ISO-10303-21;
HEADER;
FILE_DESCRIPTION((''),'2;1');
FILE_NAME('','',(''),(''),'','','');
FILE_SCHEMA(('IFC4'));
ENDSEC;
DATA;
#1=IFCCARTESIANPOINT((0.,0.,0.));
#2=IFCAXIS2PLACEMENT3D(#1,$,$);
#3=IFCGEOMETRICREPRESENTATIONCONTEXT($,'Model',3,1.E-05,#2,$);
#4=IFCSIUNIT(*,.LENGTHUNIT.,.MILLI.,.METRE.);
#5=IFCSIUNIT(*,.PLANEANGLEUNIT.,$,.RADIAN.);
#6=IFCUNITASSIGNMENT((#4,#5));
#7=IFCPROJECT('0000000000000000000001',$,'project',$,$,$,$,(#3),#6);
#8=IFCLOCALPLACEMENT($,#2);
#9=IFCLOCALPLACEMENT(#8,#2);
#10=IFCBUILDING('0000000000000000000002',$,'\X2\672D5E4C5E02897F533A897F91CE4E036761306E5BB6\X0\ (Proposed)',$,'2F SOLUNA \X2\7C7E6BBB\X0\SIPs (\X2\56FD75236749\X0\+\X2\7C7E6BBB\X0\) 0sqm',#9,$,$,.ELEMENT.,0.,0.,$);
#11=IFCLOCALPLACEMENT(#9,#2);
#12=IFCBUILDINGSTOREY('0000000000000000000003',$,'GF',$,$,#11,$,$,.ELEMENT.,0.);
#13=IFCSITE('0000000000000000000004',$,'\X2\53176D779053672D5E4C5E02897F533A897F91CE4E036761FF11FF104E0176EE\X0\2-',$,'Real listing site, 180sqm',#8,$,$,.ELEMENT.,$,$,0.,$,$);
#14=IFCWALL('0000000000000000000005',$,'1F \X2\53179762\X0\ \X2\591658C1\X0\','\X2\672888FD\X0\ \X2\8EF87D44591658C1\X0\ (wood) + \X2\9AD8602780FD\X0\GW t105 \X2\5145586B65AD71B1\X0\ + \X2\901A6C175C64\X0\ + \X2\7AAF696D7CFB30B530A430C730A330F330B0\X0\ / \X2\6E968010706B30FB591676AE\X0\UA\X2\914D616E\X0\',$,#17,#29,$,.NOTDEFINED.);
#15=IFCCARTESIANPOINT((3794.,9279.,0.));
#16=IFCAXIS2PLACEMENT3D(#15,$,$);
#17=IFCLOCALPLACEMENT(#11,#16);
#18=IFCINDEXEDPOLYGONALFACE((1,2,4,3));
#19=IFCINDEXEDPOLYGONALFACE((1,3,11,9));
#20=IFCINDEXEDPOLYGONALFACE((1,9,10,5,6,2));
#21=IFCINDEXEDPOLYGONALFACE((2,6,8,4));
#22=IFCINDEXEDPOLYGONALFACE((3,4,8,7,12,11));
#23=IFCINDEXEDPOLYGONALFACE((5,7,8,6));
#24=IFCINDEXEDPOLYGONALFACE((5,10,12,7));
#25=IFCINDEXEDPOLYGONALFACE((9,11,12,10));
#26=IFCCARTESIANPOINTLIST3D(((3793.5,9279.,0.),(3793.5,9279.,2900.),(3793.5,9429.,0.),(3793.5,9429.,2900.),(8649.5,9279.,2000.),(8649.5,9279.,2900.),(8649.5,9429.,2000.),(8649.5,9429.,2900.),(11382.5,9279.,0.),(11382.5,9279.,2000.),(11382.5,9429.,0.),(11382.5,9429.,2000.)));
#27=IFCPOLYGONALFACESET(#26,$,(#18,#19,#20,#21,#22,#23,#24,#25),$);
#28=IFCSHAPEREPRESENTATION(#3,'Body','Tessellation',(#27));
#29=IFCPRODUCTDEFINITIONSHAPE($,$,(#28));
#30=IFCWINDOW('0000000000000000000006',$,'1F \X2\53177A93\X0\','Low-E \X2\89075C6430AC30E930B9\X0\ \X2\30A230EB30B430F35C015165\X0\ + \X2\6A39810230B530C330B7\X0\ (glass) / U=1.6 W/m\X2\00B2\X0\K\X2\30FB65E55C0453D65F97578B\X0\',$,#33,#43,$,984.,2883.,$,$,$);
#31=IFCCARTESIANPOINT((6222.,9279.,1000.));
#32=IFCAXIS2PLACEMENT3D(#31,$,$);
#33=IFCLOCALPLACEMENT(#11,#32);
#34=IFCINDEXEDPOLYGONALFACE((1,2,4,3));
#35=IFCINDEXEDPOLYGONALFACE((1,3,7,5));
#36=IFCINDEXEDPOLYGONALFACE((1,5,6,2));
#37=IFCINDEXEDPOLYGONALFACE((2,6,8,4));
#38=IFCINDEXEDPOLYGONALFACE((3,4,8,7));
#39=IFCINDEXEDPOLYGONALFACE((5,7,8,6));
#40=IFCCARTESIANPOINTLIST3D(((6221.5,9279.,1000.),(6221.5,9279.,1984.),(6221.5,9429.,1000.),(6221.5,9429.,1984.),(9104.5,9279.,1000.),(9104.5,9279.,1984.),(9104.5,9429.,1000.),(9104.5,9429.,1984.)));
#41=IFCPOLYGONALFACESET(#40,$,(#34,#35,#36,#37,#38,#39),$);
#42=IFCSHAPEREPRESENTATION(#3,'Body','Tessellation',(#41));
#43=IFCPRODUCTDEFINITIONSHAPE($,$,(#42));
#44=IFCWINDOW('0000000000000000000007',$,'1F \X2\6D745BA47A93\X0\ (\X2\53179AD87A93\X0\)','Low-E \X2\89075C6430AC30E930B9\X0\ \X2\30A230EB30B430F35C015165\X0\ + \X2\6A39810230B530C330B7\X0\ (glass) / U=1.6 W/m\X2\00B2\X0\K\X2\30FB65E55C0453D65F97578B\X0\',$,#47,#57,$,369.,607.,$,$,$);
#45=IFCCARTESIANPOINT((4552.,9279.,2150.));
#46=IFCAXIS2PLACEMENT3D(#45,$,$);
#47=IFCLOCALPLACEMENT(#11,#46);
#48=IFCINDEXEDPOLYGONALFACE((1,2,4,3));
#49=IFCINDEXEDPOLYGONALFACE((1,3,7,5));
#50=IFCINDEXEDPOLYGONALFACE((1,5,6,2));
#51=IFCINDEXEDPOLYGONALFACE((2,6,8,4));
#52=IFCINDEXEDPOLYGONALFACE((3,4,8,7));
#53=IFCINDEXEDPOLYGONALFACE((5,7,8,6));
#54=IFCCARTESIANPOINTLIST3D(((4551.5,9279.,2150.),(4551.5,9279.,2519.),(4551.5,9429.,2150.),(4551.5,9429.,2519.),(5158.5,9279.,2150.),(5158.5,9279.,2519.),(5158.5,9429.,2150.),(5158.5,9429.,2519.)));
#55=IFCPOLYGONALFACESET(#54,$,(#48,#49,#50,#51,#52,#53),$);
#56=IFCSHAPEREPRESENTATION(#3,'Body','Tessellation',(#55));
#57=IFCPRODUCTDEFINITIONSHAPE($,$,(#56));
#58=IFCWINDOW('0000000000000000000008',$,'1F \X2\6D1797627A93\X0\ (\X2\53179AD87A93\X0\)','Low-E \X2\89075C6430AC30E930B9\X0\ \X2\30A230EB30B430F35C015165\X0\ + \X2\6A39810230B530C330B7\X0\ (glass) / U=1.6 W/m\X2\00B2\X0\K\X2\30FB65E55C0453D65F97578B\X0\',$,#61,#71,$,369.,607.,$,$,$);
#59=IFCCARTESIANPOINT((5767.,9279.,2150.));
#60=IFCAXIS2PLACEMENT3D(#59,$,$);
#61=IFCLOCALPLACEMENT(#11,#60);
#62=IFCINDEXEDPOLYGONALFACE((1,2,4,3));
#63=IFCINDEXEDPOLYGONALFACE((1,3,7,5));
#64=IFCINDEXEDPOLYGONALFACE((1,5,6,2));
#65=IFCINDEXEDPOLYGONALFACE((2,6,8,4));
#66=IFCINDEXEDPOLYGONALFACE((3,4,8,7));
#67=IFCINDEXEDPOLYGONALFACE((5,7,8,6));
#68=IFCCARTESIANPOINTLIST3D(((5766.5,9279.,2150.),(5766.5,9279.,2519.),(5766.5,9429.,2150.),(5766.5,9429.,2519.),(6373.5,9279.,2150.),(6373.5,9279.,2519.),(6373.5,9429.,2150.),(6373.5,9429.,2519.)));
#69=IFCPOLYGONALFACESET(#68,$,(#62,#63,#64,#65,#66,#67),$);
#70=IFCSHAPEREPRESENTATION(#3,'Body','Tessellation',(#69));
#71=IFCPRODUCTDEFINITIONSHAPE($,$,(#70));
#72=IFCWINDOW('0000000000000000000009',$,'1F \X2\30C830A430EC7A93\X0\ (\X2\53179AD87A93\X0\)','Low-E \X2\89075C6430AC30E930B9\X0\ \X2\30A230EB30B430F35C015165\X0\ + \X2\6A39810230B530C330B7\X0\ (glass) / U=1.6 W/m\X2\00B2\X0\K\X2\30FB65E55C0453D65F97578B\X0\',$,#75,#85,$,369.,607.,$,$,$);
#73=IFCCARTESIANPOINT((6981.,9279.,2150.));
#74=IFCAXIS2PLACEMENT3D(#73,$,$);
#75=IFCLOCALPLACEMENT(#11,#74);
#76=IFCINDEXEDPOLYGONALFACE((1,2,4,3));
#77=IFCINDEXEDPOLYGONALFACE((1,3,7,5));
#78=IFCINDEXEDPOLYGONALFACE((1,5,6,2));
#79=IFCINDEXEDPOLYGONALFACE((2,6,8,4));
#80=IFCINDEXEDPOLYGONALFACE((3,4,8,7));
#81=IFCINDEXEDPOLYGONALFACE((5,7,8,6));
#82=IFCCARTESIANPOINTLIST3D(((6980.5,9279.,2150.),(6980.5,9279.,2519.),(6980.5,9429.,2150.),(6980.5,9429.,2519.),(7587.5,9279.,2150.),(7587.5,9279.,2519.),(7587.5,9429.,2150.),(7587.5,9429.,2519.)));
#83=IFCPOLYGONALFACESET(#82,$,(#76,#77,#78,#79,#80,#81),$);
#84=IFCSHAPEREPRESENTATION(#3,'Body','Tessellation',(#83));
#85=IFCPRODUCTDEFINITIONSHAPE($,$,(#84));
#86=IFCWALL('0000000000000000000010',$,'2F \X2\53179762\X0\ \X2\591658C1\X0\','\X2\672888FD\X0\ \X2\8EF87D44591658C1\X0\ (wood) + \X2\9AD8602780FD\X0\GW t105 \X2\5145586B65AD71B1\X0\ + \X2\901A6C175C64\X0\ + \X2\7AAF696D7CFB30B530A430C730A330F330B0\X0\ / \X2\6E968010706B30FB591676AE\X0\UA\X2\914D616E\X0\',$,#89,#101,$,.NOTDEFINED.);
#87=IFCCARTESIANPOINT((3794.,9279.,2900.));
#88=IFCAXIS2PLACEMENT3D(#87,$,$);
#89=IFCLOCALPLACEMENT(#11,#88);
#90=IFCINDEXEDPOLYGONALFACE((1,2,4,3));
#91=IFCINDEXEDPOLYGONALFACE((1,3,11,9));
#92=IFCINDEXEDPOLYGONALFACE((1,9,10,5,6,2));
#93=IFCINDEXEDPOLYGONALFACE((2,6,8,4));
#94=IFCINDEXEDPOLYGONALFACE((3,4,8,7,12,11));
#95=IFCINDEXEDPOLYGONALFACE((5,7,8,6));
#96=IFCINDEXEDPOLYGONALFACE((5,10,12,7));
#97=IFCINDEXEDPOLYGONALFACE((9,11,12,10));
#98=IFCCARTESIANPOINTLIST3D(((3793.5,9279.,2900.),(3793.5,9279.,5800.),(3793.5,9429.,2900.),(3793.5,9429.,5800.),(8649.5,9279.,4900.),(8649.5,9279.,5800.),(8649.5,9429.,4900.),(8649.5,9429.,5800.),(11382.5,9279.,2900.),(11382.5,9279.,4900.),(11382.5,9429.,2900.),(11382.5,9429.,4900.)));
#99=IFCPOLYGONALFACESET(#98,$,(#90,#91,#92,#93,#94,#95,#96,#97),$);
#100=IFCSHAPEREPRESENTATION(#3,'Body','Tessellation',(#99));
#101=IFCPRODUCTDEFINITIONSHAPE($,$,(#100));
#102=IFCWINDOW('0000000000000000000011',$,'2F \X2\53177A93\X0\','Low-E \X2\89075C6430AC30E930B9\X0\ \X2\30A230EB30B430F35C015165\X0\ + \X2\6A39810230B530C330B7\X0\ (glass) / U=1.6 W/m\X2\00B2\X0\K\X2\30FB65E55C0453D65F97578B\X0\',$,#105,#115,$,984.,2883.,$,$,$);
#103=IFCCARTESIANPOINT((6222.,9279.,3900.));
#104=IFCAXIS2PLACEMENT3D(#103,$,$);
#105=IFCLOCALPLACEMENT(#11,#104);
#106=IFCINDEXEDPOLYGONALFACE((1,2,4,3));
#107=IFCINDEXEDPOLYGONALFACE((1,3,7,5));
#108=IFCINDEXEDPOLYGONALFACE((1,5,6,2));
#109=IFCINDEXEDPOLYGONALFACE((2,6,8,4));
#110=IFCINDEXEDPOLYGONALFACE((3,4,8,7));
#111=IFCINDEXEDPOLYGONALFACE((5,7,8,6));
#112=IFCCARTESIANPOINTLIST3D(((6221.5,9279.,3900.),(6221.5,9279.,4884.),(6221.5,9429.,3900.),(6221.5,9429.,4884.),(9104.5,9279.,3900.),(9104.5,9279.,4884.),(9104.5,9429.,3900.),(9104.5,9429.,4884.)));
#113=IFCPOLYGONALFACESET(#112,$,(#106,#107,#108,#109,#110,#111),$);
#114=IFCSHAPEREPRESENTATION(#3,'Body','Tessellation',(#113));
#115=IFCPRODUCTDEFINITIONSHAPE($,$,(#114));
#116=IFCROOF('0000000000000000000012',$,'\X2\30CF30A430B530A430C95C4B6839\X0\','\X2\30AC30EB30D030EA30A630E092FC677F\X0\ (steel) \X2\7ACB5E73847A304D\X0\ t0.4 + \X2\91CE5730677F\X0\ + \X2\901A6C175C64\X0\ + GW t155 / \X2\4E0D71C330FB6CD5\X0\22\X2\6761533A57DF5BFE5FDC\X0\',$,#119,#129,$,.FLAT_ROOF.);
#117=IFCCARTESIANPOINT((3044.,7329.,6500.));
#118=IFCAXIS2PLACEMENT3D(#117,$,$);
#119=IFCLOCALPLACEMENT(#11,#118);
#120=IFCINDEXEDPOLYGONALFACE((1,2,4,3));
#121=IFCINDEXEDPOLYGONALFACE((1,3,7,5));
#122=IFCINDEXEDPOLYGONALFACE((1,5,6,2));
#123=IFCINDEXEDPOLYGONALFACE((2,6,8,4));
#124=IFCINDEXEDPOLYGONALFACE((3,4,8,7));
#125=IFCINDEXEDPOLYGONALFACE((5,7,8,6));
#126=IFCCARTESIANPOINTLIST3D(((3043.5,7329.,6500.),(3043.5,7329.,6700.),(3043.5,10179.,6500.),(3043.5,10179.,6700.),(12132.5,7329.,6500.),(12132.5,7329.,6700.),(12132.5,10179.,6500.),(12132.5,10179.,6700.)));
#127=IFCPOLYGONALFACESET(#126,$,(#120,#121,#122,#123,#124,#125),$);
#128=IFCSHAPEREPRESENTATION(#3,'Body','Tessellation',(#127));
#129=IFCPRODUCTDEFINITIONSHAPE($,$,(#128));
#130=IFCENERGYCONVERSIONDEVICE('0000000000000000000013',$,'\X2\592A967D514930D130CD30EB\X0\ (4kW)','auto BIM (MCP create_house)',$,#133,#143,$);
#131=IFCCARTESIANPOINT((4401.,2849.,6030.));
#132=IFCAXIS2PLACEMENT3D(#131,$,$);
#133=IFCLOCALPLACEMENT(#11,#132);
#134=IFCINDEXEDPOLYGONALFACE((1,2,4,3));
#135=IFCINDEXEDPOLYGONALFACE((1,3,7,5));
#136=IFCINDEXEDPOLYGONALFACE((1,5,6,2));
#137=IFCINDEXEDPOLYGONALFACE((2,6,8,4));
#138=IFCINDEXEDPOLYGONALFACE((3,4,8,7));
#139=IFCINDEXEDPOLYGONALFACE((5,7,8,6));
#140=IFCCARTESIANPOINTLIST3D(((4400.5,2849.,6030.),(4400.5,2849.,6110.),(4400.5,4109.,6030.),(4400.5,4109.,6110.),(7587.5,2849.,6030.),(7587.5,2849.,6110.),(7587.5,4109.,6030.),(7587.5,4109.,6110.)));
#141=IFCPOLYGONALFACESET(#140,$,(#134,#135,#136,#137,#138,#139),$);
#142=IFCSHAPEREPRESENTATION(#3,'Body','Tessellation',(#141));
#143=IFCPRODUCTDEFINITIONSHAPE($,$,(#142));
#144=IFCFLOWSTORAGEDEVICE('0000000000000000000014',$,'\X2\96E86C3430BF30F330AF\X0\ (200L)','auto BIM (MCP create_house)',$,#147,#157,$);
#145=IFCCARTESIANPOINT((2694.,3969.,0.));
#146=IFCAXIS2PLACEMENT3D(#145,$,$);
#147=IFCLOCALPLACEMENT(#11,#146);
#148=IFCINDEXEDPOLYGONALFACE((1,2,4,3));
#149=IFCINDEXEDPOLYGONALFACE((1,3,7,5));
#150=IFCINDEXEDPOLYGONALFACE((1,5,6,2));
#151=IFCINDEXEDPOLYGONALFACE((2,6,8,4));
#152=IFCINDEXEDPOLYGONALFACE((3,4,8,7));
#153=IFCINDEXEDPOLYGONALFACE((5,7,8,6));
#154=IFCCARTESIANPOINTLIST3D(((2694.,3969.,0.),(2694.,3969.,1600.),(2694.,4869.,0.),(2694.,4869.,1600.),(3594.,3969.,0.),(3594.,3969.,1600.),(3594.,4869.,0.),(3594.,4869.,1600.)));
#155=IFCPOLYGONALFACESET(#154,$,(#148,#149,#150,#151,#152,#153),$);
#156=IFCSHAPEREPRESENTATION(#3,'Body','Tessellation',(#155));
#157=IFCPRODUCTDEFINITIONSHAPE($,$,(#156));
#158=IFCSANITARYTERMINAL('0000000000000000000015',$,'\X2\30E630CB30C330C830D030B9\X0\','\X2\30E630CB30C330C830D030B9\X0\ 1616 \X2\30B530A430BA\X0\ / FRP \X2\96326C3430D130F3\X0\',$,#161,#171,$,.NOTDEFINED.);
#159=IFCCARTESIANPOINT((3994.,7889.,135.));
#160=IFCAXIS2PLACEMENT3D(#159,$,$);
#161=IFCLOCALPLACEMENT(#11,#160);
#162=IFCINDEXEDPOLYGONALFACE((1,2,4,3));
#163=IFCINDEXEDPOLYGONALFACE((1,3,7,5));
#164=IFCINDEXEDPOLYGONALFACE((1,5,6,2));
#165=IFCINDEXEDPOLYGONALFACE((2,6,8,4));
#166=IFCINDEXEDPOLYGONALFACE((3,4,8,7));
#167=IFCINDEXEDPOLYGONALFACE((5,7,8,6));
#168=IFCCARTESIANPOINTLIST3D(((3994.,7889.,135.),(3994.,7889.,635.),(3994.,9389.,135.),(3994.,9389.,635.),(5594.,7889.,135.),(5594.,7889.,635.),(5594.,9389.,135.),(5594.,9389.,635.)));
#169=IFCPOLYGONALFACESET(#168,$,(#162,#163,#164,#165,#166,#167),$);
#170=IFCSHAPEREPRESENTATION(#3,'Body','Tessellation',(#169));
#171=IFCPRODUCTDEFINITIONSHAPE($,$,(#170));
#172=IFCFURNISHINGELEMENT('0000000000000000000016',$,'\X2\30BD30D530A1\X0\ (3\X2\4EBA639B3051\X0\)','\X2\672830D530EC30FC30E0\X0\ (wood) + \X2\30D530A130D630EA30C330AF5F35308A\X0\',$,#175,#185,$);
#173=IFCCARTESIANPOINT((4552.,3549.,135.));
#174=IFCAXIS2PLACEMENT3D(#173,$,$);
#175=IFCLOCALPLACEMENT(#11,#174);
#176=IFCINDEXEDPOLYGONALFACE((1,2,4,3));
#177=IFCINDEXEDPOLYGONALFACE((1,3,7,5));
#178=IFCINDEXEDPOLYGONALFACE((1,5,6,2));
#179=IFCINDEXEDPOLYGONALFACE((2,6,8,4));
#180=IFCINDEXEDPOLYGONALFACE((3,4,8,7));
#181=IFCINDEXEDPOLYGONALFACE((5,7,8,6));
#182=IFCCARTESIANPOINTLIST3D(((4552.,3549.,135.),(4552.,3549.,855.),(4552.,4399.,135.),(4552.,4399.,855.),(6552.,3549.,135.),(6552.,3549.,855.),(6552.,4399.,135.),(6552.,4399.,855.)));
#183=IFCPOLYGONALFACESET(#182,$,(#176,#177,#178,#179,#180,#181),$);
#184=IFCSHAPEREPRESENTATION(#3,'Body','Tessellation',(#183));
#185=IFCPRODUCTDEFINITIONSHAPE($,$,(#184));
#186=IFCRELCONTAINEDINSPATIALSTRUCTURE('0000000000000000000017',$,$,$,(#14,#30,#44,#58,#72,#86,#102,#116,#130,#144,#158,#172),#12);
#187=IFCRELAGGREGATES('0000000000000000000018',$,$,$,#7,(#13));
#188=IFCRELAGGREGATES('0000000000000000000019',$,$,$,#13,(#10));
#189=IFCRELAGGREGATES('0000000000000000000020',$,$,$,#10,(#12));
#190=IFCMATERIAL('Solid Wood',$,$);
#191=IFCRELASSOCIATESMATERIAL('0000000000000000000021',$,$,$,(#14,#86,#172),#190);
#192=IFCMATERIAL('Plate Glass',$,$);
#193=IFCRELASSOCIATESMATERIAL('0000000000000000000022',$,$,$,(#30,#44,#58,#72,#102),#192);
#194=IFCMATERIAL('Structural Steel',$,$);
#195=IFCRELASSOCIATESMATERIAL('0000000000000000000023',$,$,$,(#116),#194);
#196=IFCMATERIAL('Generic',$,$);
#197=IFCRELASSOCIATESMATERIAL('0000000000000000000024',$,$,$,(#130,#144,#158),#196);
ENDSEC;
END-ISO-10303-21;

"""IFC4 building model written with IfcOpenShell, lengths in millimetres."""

from ifc_helpers import new_model, si_unit, frame, frame_2d, origin, place, context, project, spatial, rectangle, extrude, material, element, fill, save


model = new_model("IFC4")

# Units and contexts
model_context = context("Model", 3, precision=1e-05, world=origin())
ifc_project = project(units=[si_unit("LENGTHUNIT", "METRE", prefix="MILLI"), si_unit("PLANEANGLEUNIT", "RADIAN")], contexts=[model_context])

# Site, building, storey
site_placement = place(None, origin())
site = spatial("IfcSite", under=ifc_project, at=site_placement, Name="北海道札幌市西区西野七条１０丁目2-", ObjectType="Real listing site, 180sqm", CompositionType="ELEMENT", RefElevation=0.0)
building_placement = place(site_placement, origin())
building = spatial("IfcBuilding", under=site, at=building_placement, Name="札幌市西区西野七条の家 (Proposed)", ObjectType="2F SOLUNA 籾殻SIPs (国産杉+籾殻) 0sqm", CompositionType="ELEMENT", ElevationOfRefHeight=0.0, ElevationOfTerrain=0.0)
storey_placement = place(building_placement, origin())
storey = spatial("IfcBuildingStorey", under=building, at=storey_placement, Name="GF", CompositionType="ELEMENT", Elevation=0.0)

# Wall, openings, windows
ifc_material_1 = material(Name="Solid Wood")
wall_1_placement = place(storey_placement, frame((3794.0, 9279.0, 0.0)))
wall_1 = element("IfcWall", 1, at=wall_1_placement, inside=storey, material=ifc_material_1, Name="1F 北面 外壁", Description="木製 軸組外壁 (wood) + 高性能GW t105 充填断熱 + 通気層 + 窯業系サイディング / 準耐火・外皮UA配慮", PredefinedType="NOTDEFINED", context=model_context, shape_type="SweptSolid", body=[
    extrude(rectangle(XDim=7589.0, YDim=150.0, at=frame_2d((3794.0, 75.0))), frame((3794.0, 9279.0, 0.0)), (0.0, 0.0, 1.0), 2900.0),
])
opening_1_placement = place(storey_placement, frame((6222.0, 9279.0, 1000.0)))
opening_1 = element("IfcOpeningElement", 2, at=opening_1_placement, cuts=wall_1, PredefinedType="NOTDEFINED", context=model_context, shape_type="SweptSolid", body=[
    extrude(rectangle(XDim=2883.0, YDim=150.0, at=frame_2d((1441.0, 75.0))), frame((6222.0, 9279.0, 1000.0)), (0.0, 0.0, 1.0), 984.0),
])
opening_2_placement = place(storey_placement, frame((4552.0, 9279.0, 2150.0)))
opening_2 = element("IfcOpeningElement", 3, at=opening_2_placement, cuts=wall_1, PredefinedType="NOTDEFINED", context=model_context, shape_type="SweptSolid", body=[
    extrude(rectangle(XDim=607.0, YDim=150.0, at=frame_2d((303.0, 75.0))), frame((4552.0, 9279.0, 2150.0)), (0.0, 0.0, 1.0), 369.0),
])
opening_3_placement = place(storey_placement, frame((5767.0, 9279.0, 2150.0)))
opening_3 = element("IfcOpeningElement", 4, at=opening_3_placement, cuts=wall_1, PredefinedType="NOTDEFINED", context=model_context, shape_type="SweptSolid", body=[
    extrude(rectangle(XDim=607.0, YDim=150.0, at=frame_2d((303.0, 75.0))), frame((5767.0, 9279.0, 2150.0)), (0.0, 0.0, 1.0), 369.0),
])
opening_4_placement = place(storey_placement, frame((6981.0, 9279.0, 2150.0)))
opening_4 = element("IfcOpeningElement", 5, at=opening_4_placement, cuts=wall_1, PredefinedType="NOTDEFINED", context=model_context, shape_type="SweptSolid", body=[
    extrude(rectangle(XDim=607.0, YDim=150.0, at=frame_2d((303.0, 75.0))), frame((6981.0, 9279.0, 2150.0)), (0.0, 0.0, 1.0), 369.0),
])
ifc_material_2 = material(Name="Plate Glass")
window_1_placement = place(storey_placement, frame((6222.0, 9279.0, 1000.0)))
window_1 = element("IfcWindow", 6, at=window_1_placement, inside=storey, material=ifc_material_2, Name="1F 北窓", Description="Low-E 複層ガラス アルゴン封入 + 樹脂サッシ (glass) / U=1.6 W/m²K・日射取得型", OverallHeight=984.0, OverallWidth=2883.0, context=model_context, shape_type="SweptSolid", body=[
    extrude(rectangle(XDim=2883.0, YDim=150.0, at=frame_2d((1441.0, 75.0))), frame((6222.0, 9279.0, 1000.0)), (0.0, 0.0, 1.0), 984.0),
])
fill(opening_1, window_1)
window_2_placement = place(storey_placement, frame((4552.0, 9279.0, 2150.0)))
window_2 = element("IfcWindow", 7, at=window_2_placement, inside=storey, material=ifc_material_2, Name="1F 浴室窓 (北高窓)", Description="Low-E 複層ガラス アルゴン封入 + 樹脂サッシ (glass) / U=1.6 W/m²K・日射取得型", OverallHeight=369.0, OverallWidth=607.0, context=model_context, shape_type="SweptSolid", body=[
    extrude(rectangle(XDim=607.0, YDim=150.0, at=frame_2d((303.0, 75.0))), frame((4552.0, 9279.0, 2150.0)), (0.0, 0.0, 1.0), 369.0),
])
fill(opening_2, window_2)
window_3_placement = place(storey_placement, frame((5767.0, 9279.0, 2150.0)))
window_3 = element("IfcWindow", 8, at=window_3_placement, inside=storey, material=ifc_material_2, Name="1F 洗面窓 (北高窓)", Description="Low-E 複層ガラス アルゴン封入 + 樹脂サッシ (glass) / U=1.6 W/m²K・日射取得型", OverallHeight=369.0, OverallWidth=607.0, context=model_context, shape_type="SweptSolid", body=[
    extrude(rectangle(XDim=607.0, YDim=150.0, at=frame_2d((303.0, 75.0))), frame((5767.0, 9279.0, 2150.0)), (0.0, 0.0, 1.0), 369.0),
])
fill(opening_3, window_3)
window_4_placement = place(storey_placement, frame((6981.0, 9279.0, 2150.0)))
window_4 = element("IfcWindow", 9, at=window_4_placement, inside=storey, material=ifc_material_2, Name="1F トイレ窓 (北高窓)", Description="Low-E 複層ガラス アルゴン封入 + 樹脂サッシ (glass) / U=1.6 W/m²K・日射取得型", OverallHeight=369.0, OverallWidth=607.0, context=model_context, shape_type="SweptSolid", body=[
    extrude(rectangle(XDim=607.0, YDim=150.0, at=frame_2d((303.0, 75.0))), frame((6981.0, 9279.0, 2150.0)), (0.0, 0.0, 1.0), 369.0),
])
fill(opening_4, window_4)

# Wall, opening, window
wall_2_placement = place(storey_placement, frame((3794.0, 9279.0, 2900.0)))
wall_2 = element("IfcWall", 10, at=wall_2_placement, inside=storey, material=ifc_material_1, Name="2F 北面 外壁", Description="木製 軸組外壁 (wood) + 高性能GW t105 充填断熱 + 通気層 + 窯業系サイディング / 準耐火・外皮UA配慮", PredefinedType="NOTDEFINED", context=model_context, shape_type="SweptSolid", body=[
    extrude(rectangle(XDim=7589.0, YDim=150.0, at=frame_2d((3794.0, 75.0))), frame((3794.0, 9279.0, 2900.0)), (0.0, 0.0, 1.0), 2900.0),
])
opening_5_placement = place(storey_placement, frame((6222.0, 9279.0, 3900.0)))
opening_5 = element("IfcOpeningElement", 11, at=opening_5_placement, cuts=wall_2, PredefinedType="NOTDEFINED", context=model_context, shape_type="SweptSolid", body=[
    extrude(rectangle(XDim=2883.0, YDim=150.0, at=frame_2d((1441.0, 75.0))), frame((6222.0, 9279.0, 3900.0)), (0.0, 0.0, 1.0), 984.0),
])
window_5_placement = place(storey_placement, frame((6222.0, 9279.0, 3900.0)))
window_5 = element("IfcWindow", 12, at=window_5_placement, inside=storey, material=ifc_material_2, Name="2F 北窓", Description="Low-E 複層ガラス アルゴン封入 + 樹脂サッシ (glass) / U=1.6 W/m²K・日射取得型", OverallHeight=984.0, OverallWidth=2883.0, context=model_context, shape_type="SweptSolid", body=[
    extrude(rectangle(XDim=2883.0, YDim=150.0, at=frame_2d((1441.0, 75.0))), frame((6222.0, 9279.0, 3900.0)), (0.0, 0.0, 1.0), 984.0),
])
fill(opening_5, window_5)

# Roof
ifc_material_3 = material(Name="Structural Steel")
roof_placement = place(storey_placement, frame((3044.0, 7329.0, 6500.0)))
element("IfcRoof", 13, at=roof_placement, inside=storey, material=ifc_material_3, Name="ハイサイド屋根", Description="ガルバリウム鋼板 (steel) 立平葺き t0.4 + 野地板 + 通気層 + GW t155 / 不燃・法22条区域対応", PredefinedType="FLAT_ROOF", context=model_context, shape_type="SweptSolid", body=[
    extrude(rectangle(XDim=9089.0, YDim=2850.0, at=frame_2d((4544.0, 1425.0))), frame((3044.0, 7329.0, 6500.0)), (0.0, 0.0, 1.0), 200.0),
])

# Energy conversion device
ifc_material_4 = material(Name="Generic")
energy_conversion_device_placement = place(storey_placement, frame((4401.0, 2849.0, 6030.0)))
element("IfcEnergyConversionDevice", 14, at=energy_conversion_device_placement, inside=storey, material=ifc_material_4, Name="太陽光パネル (4kW)", Description="auto BIM (MCP create_house)", context=model_context, shape_type="SweptSolid", body=[
    extrude(rectangle(XDim=3187.0, YDim=1260.0, at=frame_2d((1593.0, 630.0))), frame((4401.0, 2849.0, 6030.0)), (0.0, 0.0, 1.0), 80.0),
])

# Flow storage device
flow_storage_device_placement = place(storey_placement, frame((2694.0, 3969.0, 0.0)))
element("IfcFlowStorageDevice", 15, at=flow_storage_device_placement, inside=storey, material=ifc_material_4, Name="雨水タンク (200L)", Description="auto BIM (MCP create_house)", context=model_context, shape_type="SweptSolid", body=[
    extrude(rectangle(XDim=900.0, YDim=900.0, at=frame_2d((450.0, 450.0))), frame((2694.0, 3969.0, 0.0)), (0.0, 0.0, 1.0), 1600.0),
])

# Sanitary terminal
sanitary_terminal_placement = place(storey_placement, frame((3994.0, 7889.0, 135.0)))
element("IfcSanitaryTerminal", 16, at=sanitary_terminal_placement, inside=storey, material=ifc_material_4, Name="ユニットバス", Description="ユニットバス 1616 サイズ / FRP 防水パン", PredefinedType="NOTDEFINED", context=model_context, shape_type="SweptSolid", body=[
    extrude(rectangle(XDim=1600.0, YDim=1500.0, at=frame_2d((800.0, 750.0))), frame((3994.0, 7889.0, 135.0)), (0.0, 0.0, 1.0), 500.0),
])

# Furnishing element
furnishing_1_placement = place(storey_placement, frame((4552.0, 3549.0, 135.0)))
element("IfcFurnishingElement", 17, at=furnishing_1_placement, inside=storey, material=ifc_material_1, Name="ソファ (3人掛け)", Description="木フレーム (wood) + ファブリック張り", context=model_context, shape_type="SweptSolid", body=[
    extrude(rectangle(XDim=2000.0, YDim=850.0, at=frame_2d((1000.0, 425.0))), frame((4552.0, 3549.0, 135.0)), (0.0, 0.0, 1.0), 720.0),
])

save(model, "model.ifc")
